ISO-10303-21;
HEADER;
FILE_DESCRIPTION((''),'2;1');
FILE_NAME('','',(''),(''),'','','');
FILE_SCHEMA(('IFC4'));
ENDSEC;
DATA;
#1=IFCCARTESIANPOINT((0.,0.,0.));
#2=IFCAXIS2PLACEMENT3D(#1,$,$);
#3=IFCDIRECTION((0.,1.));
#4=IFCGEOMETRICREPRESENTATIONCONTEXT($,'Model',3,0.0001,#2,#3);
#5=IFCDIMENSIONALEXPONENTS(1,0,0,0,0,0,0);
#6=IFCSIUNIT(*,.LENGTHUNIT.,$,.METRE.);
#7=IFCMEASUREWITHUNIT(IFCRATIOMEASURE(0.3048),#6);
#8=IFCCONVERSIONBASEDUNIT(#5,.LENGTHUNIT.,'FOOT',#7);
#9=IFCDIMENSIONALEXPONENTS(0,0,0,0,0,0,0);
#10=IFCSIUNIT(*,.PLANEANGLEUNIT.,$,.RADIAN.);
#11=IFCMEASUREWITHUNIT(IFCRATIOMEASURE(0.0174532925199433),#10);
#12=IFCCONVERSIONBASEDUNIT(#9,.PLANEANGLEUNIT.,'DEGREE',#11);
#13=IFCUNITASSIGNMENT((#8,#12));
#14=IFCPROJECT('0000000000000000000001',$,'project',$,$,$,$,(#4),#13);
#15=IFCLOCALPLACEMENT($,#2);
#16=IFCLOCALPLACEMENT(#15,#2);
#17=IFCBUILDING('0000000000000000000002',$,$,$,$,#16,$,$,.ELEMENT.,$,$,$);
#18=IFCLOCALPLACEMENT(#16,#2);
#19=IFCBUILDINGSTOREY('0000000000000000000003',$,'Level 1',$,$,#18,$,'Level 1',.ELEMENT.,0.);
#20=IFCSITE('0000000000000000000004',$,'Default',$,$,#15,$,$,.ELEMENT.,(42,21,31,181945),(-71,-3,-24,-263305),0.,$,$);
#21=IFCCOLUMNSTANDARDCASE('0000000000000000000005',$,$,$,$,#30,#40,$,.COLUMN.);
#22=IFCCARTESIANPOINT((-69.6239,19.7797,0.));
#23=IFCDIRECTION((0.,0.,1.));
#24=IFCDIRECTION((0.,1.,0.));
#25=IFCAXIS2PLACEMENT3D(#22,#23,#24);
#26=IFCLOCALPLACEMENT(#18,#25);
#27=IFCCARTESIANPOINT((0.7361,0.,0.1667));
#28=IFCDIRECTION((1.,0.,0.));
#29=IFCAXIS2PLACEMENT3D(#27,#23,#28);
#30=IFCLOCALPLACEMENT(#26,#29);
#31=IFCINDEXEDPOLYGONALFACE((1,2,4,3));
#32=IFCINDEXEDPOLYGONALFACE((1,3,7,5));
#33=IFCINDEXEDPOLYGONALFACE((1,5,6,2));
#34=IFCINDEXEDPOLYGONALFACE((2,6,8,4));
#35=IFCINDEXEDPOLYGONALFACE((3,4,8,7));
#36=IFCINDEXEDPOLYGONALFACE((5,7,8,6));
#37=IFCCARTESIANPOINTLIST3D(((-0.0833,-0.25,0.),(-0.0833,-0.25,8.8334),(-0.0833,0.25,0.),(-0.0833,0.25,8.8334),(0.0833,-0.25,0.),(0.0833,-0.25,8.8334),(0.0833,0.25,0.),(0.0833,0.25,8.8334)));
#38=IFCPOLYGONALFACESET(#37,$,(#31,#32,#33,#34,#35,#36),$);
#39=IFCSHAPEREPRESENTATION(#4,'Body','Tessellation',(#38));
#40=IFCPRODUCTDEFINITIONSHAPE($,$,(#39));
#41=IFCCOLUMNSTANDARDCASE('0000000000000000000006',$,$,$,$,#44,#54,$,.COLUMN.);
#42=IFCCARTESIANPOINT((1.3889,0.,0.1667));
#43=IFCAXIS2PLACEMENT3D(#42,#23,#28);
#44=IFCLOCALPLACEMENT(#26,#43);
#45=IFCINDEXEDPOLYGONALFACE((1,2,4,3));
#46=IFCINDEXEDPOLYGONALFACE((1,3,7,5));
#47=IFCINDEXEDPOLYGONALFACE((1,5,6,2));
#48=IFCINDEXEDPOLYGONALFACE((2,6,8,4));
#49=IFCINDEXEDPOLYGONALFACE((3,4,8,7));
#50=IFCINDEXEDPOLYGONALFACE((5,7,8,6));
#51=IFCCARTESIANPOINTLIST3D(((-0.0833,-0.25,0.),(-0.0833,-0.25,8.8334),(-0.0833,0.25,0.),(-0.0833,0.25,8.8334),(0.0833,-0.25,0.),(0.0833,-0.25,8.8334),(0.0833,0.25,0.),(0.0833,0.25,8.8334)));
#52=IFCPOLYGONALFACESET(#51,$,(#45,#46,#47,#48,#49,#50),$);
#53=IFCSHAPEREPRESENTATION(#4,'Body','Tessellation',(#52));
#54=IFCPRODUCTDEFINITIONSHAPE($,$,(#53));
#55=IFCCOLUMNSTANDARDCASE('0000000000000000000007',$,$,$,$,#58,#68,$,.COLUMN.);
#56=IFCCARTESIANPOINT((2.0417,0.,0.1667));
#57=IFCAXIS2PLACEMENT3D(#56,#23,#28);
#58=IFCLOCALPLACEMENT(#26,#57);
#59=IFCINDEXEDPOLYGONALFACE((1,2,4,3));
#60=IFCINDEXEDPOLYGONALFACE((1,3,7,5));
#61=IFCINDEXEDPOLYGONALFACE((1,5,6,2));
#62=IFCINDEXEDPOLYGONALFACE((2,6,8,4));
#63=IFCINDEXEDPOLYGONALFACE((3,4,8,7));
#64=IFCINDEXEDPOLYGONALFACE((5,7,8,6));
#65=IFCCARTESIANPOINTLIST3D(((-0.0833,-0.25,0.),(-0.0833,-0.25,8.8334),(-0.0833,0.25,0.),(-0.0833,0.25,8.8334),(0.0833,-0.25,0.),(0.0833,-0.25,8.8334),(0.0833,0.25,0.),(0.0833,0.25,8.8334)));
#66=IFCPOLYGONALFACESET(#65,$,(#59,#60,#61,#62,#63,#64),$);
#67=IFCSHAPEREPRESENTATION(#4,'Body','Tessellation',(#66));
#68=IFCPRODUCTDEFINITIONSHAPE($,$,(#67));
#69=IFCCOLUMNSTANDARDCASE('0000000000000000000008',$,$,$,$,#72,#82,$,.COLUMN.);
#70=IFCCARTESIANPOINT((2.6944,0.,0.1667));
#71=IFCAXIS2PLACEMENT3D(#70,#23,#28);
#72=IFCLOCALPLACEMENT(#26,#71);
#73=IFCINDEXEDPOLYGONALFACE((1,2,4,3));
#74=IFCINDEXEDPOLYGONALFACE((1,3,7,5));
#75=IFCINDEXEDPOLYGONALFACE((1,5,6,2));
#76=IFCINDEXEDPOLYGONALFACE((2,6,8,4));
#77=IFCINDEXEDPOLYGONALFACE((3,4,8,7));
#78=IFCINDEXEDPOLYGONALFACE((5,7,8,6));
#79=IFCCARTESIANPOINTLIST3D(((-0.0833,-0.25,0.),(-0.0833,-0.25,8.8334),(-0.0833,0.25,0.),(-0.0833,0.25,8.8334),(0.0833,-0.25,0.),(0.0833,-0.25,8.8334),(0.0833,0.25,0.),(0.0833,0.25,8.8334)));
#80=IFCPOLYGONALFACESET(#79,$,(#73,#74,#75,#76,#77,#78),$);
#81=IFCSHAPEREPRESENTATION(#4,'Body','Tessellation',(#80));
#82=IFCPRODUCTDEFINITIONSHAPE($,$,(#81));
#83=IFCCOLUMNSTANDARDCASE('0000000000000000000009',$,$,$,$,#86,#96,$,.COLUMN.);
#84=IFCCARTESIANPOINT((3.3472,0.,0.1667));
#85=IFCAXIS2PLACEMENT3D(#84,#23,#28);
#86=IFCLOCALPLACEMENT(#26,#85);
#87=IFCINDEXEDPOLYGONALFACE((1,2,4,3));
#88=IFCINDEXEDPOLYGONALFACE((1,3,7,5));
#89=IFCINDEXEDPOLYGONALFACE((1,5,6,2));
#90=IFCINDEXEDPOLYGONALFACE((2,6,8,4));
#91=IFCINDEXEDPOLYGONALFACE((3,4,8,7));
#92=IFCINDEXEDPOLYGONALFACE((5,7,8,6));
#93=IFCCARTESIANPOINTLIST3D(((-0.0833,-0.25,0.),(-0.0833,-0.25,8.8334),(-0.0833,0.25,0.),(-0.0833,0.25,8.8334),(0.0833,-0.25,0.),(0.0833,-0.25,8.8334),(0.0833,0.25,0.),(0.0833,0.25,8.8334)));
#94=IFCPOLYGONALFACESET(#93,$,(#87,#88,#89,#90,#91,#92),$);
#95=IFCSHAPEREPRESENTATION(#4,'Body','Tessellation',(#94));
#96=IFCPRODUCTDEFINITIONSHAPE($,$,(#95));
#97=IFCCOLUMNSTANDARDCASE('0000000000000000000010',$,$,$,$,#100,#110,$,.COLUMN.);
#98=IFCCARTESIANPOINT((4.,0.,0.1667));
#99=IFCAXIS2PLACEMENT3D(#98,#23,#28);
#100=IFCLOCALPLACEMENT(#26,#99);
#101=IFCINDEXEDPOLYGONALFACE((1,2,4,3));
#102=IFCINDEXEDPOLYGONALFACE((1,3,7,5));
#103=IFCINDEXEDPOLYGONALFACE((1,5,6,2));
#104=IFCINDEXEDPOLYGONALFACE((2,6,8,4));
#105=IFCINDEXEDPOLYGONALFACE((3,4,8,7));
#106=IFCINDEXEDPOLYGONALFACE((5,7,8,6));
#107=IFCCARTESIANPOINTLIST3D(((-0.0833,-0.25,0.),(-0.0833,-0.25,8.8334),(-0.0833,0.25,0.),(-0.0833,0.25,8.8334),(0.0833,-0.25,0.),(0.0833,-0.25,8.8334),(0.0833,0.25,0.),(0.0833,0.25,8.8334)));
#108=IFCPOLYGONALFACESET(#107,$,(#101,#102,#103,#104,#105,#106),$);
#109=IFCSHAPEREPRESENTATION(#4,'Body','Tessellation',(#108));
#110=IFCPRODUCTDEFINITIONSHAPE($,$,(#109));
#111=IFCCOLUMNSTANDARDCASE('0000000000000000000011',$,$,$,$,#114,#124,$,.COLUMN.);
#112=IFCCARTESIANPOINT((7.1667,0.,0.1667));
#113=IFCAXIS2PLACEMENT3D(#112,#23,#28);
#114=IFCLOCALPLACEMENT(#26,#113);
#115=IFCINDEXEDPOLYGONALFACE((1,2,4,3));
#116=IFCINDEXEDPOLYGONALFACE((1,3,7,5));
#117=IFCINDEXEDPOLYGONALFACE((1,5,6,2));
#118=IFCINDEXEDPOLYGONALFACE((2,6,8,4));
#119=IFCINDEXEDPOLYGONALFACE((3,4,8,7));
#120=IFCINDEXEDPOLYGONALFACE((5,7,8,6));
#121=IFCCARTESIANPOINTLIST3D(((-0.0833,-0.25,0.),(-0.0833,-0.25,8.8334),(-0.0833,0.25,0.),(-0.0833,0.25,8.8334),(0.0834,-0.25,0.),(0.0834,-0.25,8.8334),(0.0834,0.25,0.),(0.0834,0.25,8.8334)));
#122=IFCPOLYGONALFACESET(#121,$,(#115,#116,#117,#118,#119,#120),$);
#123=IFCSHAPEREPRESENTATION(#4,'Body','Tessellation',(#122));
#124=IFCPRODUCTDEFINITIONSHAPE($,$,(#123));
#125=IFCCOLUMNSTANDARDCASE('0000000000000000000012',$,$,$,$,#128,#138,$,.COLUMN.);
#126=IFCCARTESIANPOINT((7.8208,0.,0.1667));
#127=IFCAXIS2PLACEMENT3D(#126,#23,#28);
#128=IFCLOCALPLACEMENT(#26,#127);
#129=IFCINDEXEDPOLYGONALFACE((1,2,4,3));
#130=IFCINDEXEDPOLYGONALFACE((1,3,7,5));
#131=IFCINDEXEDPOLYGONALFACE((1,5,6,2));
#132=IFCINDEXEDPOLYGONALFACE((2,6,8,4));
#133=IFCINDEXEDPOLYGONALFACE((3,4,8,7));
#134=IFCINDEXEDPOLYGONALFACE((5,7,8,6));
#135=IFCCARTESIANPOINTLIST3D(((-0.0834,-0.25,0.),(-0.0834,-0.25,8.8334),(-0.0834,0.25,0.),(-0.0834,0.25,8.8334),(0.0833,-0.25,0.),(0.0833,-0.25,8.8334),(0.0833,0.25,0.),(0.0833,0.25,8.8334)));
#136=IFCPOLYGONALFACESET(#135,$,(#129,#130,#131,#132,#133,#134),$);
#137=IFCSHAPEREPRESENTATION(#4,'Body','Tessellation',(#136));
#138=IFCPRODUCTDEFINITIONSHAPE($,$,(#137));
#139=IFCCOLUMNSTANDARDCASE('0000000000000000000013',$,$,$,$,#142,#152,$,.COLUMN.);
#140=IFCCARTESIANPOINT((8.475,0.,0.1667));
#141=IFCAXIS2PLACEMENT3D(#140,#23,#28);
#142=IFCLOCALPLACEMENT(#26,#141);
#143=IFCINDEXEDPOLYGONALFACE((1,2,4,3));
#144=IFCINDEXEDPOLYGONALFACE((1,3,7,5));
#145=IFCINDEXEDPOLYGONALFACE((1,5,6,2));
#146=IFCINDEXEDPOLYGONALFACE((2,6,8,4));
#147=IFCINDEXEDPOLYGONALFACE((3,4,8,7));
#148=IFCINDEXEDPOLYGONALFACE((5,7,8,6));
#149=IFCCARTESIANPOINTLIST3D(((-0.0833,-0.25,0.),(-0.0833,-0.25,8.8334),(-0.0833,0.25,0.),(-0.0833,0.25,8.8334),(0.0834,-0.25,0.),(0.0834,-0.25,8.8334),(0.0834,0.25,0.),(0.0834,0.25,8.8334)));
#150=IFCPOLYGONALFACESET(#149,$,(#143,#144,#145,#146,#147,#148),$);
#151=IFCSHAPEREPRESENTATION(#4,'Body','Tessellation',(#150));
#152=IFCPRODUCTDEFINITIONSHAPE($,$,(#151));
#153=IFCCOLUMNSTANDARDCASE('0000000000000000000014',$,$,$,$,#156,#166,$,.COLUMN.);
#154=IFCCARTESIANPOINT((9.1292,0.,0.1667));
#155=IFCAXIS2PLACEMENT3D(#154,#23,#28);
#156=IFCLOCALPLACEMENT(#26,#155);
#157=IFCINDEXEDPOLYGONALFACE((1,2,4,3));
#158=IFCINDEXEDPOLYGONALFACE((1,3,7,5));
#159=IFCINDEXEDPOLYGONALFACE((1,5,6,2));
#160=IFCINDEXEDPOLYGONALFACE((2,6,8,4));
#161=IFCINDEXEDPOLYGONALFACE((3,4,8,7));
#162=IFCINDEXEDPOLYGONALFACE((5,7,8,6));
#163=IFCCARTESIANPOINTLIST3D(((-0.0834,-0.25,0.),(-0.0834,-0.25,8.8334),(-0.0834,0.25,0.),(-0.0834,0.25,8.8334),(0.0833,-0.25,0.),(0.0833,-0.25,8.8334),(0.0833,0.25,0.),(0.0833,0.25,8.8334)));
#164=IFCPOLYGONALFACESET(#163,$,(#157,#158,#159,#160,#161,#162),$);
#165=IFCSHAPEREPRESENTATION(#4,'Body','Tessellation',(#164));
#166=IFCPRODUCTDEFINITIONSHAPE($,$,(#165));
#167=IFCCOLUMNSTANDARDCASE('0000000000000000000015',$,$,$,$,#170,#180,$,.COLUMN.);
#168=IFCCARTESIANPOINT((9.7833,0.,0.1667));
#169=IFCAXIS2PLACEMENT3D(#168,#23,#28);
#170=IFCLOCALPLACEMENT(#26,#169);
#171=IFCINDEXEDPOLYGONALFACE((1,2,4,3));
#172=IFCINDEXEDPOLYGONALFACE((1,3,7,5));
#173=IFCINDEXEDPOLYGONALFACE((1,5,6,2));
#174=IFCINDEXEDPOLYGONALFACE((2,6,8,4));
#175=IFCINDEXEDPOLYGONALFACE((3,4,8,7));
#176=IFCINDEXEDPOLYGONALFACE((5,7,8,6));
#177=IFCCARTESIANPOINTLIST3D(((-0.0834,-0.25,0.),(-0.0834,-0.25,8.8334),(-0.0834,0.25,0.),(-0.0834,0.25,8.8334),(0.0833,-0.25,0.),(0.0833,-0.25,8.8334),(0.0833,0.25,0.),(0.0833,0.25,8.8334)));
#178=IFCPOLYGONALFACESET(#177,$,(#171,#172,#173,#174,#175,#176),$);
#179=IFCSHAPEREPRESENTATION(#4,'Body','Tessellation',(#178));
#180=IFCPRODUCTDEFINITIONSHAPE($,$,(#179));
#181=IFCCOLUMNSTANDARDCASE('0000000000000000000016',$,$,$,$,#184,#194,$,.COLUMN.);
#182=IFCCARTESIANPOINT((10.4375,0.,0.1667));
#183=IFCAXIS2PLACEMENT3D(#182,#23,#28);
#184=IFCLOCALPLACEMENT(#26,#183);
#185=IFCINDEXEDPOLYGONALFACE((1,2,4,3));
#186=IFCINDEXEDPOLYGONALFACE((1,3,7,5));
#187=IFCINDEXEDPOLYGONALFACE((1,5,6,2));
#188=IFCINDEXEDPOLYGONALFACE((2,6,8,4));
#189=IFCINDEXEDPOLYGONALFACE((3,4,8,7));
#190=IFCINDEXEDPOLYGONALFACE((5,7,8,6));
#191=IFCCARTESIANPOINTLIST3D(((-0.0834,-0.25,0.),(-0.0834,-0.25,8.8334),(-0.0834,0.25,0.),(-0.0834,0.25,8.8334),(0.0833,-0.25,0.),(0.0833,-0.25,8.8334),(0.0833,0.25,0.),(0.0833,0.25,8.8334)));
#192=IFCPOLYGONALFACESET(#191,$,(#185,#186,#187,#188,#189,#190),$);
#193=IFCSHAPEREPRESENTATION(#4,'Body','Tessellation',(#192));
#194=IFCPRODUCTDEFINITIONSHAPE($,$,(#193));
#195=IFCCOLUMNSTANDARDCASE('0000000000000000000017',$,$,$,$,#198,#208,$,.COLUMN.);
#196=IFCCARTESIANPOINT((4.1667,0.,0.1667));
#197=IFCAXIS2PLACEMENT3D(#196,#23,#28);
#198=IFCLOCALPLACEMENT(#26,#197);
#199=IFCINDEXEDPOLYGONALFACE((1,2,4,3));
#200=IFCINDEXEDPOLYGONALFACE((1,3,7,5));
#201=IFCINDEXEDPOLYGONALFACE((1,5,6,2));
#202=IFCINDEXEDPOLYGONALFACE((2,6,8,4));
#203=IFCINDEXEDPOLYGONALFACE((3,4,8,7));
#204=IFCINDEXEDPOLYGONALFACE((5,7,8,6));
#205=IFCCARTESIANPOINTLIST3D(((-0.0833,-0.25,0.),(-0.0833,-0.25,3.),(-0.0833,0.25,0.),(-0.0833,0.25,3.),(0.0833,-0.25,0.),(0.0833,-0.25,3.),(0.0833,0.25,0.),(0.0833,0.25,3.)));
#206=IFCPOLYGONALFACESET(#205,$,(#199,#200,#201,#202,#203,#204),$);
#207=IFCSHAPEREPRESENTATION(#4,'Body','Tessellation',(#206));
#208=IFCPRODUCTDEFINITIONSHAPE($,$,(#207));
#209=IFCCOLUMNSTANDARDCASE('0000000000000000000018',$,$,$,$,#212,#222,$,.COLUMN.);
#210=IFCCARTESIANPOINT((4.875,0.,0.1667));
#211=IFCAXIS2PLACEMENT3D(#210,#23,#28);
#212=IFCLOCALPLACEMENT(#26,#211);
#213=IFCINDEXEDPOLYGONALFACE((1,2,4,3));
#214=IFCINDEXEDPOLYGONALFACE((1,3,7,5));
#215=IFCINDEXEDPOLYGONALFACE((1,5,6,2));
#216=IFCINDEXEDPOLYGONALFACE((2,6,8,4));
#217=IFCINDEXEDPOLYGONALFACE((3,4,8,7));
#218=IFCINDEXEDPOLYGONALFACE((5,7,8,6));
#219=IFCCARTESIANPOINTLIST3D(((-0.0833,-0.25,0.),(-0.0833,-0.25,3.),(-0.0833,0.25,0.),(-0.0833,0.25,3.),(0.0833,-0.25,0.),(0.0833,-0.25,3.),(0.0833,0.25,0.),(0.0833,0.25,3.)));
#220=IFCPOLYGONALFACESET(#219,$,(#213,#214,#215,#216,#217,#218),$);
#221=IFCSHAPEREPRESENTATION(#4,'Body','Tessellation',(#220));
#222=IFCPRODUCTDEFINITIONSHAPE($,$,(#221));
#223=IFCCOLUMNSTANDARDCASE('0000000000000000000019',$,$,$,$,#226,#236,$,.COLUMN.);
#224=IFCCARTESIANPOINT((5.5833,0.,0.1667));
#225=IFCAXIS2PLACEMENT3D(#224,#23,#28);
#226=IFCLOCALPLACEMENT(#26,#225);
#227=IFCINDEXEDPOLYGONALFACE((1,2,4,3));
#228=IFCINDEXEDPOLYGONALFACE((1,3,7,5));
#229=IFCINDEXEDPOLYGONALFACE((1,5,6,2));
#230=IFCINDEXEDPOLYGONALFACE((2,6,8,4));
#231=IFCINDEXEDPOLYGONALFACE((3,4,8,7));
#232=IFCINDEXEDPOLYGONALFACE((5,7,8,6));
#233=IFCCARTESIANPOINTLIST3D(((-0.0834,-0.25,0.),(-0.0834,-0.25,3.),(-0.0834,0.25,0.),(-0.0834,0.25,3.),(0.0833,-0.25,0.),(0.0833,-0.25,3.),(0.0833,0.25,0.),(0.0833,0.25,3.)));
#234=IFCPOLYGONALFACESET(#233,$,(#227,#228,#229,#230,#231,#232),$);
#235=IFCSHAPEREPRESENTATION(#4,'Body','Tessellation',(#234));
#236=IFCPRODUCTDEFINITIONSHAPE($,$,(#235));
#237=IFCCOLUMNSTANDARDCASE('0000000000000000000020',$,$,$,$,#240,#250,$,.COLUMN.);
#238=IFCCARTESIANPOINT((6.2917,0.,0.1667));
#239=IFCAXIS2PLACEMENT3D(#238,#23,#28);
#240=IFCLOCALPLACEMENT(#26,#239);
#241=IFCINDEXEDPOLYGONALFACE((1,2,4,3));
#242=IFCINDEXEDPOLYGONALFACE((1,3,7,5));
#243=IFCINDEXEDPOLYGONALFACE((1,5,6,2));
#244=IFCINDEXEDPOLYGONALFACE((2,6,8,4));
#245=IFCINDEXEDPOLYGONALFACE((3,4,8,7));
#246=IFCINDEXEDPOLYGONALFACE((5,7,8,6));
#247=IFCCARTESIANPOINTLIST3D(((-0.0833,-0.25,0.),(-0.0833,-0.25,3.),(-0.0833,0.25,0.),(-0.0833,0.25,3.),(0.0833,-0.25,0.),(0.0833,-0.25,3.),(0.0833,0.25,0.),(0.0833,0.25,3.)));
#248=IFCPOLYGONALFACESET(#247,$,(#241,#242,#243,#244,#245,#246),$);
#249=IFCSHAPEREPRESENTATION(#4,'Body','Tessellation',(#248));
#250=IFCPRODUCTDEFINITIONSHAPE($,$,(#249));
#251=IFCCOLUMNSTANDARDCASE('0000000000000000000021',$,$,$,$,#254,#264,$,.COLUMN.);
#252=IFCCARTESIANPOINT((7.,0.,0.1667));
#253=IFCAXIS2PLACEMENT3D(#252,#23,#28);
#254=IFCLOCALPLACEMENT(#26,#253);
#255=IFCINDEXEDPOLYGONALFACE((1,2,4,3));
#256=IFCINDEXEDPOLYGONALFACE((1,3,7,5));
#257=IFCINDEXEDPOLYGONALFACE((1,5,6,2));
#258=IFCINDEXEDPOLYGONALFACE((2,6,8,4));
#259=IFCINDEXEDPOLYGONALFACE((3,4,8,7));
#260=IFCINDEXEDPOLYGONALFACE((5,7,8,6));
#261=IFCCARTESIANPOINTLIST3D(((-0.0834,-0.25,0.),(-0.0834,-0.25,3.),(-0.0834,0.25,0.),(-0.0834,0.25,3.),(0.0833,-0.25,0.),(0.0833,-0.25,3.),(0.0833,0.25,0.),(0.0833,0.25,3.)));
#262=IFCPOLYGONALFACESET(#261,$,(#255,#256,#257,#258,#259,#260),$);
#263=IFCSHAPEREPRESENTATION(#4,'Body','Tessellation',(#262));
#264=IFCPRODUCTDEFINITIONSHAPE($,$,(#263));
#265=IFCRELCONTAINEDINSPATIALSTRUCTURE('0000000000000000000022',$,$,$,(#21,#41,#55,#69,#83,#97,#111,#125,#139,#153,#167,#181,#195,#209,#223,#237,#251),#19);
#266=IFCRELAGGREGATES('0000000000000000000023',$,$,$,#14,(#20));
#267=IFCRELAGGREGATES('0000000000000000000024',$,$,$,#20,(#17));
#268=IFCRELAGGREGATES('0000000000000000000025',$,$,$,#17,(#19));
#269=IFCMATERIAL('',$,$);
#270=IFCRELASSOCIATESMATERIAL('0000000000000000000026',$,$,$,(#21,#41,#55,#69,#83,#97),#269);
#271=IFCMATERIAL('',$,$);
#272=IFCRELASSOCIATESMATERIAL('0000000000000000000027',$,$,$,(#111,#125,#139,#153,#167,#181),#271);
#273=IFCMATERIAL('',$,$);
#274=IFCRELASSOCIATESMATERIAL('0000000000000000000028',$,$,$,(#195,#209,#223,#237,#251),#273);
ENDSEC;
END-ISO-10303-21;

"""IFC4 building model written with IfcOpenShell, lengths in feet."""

from ifc_helpers import new_model, entity, si_unit, converted_unit, direction, frame, origin, place, context, project, spatial, rectangle, extrude, material, element, save


model = new_model("IFC4")

# Units and contexts
model_context = context("Model", 3, precision=0.0001, world=origin(), true_north=direction((0.0, 1.0)))
ifc_project = project(units=[converted_unit("LENGTHUNIT", "FOOT", entity("IfcRatioMeasure", 0.3048), si_unit("LENGTHUNIT", "METRE"), dimensions=[1, 0, 0, 0, 0, 0, 0]), converted_unit("PLANEANGLEUNIT", "DEGREE", entity("IfcRatioMeasure", 0.0174532925199433), si_unit("PLANEANGLEUNIT", "RADIAN"), dimensions=[0, 0, 0, 0, 0, 0, 0])], contexts=[model_context])

# Site, building, storey
site_placement = place(None, origin())
site = spatial("IfcSite", under=ifc_project, at=site_placement, Name="Default", CompositionType="ELEMENT", RefLatitude=(42, 21, 31, 181945), RefLongitude=(-71, -3, -24, -263305), RefElevation=0.0)
building_placement = place(site_placement, origin())
building = spatial("IfcBuilding", under=site, at=building_placement, CompositionType="ELEMENT")
storey_placement = place(building_placement, origin())
storey = spatial("IfcBuildingStorey", under=building, at=storey_placement, Name="Level 1", LongName="Level 1", CompositionType="ELEMENT", Elevation=0.0)

# Columns
ifc_material_1 = material(Name="")
placement_1 = place(storey_placement, frame((-69.6239, 19.7797, 0.0), z_axis=(0.0, 0.0, 1.0), x_axis=(0.0, 1.0, 0.0)))
for number, where, z_axis, x_axis in (
    (1, (0.7361, 0.0, 0.1667), (0.0, 0.0, 1.0), (1.0, 0.0, 0.0)),
    (2, (1.3889, 0.0, 0.1667), (0.0, 0.0, 1.0), (1.0, 0.0, 0.0)),
    (3, (2.0417, 0.0, 0.1667), (0.0, 0.0, 1.0), (1.0, 0.0, 0.0)),
    (4, (2.6944, 0.0, 0.1667), (0.0, 0.0, 1.0), (1.0, 0.0, 0.0)),
    (5, (3.3472, 0.0, 0.1667), (0.0, 0.0, 1.0), (1.0, 0.0, 0.0)),
    (6, (4.0, 0.0, 0.1667), (0.0, 0.0, 1.0), (1.0, 0.0, 0.0)),
):
    element("IfcColumnStandardCase", number, at=place(placement_1, frame(where, z_axis=z_axis, x_axis=x_axis)), inside=storey, material=ifc_material_1, PredefinedType="COLUMN", context=model_context, shape_type="SweptSolid", body=[
        extrude(rectangle(XDim=0.1667, YDim=0.5), origin(), (0.0, 0.0, 1.0), 8.8334),
    ])
ifc_material_2 = material(Name="")
for number, where, z_axis, x_axis in (
    (7, (7.1667, 0.0, 0.1667), (0.0, 0.0, 1.0), (1.0, 0.0, 0.0)),
    (8, (7.8208, 0.0, 0.1667), (0.0, 0.0, 1.0), (1.0, 0.0, 0.0)),
    (9, (8.475, 0.0, 0.1667), (0.0, 0.0, 1.0), (1.0, 0.0, 0.0)),
    (10, (9.1292, 0.0, 0.1667), (0.0, 0.0, 1.0), (1.0, 0.0, 0.0)),
    (11, (9.7833, 0.0, 0.1667), (0.0, 0.0, 1.0), (1.0, 0.0, 0.0)),
    (12, (10.4375, 0.0, 0.1667), (0.0, 0.0, 1.0), (1.0, 0.0, 0.0)),
):
    element("IfcColumnStandardCase", number, at=place(placement_1, frame(where, z_axis=z_axis, x_axis=x_axis)), inside=storey, material=ifc_material_2, PredefinedType="COLUMN", context=model_context, shape_type="SweptSolid", body=[
        extrude(rectangle(XDim=0.1667, YDim=0.5), origin(), (0.0, 0.0, 1.0), 8.8334),
    ])
ifc_material_3 = material(Name="")
for number, where, z_axis, x_axis in (
    (13, (4.1667, 0.0, 0.1667), (0.0, 0.0, 1.0), (1.0, 0.0, 0.0)),
    (14, (4.875, 0.0, 0.1667), (0.0, 0.0, 1.0), (1.0, 0.0, 0.0)),
    (15, (5.5833, 0.0, 0.1667), (0.0, 0.0, 1.0), (1.0, 0.0, 0.0)),
    (16, (6.2917, 0.0, 0.1667), (0.0, 0.0, 1.0), (1.0, 0.0, 0.0)),
    (17, (7.0, 0.0, 0.1667), (0.0, 0.0, 1.0), (1.0, 0.0, 0.0)),
):
    element("IfcColumnStandardCase", number, at=place(placement_1, frame(where, z_axis=z_axis, x_axis=x_axis)), inside=storey, material=ifc_material_3, PredefinedType="COLUMN", context=model_context, shape_type="SweptSolid", body=[
        extrude(rectangle(XDim=0.1667, YDim=0.5), origin(), (0.0, 0.0, 1.0), 3.0),
    ])

save(model, "model.ifc")
